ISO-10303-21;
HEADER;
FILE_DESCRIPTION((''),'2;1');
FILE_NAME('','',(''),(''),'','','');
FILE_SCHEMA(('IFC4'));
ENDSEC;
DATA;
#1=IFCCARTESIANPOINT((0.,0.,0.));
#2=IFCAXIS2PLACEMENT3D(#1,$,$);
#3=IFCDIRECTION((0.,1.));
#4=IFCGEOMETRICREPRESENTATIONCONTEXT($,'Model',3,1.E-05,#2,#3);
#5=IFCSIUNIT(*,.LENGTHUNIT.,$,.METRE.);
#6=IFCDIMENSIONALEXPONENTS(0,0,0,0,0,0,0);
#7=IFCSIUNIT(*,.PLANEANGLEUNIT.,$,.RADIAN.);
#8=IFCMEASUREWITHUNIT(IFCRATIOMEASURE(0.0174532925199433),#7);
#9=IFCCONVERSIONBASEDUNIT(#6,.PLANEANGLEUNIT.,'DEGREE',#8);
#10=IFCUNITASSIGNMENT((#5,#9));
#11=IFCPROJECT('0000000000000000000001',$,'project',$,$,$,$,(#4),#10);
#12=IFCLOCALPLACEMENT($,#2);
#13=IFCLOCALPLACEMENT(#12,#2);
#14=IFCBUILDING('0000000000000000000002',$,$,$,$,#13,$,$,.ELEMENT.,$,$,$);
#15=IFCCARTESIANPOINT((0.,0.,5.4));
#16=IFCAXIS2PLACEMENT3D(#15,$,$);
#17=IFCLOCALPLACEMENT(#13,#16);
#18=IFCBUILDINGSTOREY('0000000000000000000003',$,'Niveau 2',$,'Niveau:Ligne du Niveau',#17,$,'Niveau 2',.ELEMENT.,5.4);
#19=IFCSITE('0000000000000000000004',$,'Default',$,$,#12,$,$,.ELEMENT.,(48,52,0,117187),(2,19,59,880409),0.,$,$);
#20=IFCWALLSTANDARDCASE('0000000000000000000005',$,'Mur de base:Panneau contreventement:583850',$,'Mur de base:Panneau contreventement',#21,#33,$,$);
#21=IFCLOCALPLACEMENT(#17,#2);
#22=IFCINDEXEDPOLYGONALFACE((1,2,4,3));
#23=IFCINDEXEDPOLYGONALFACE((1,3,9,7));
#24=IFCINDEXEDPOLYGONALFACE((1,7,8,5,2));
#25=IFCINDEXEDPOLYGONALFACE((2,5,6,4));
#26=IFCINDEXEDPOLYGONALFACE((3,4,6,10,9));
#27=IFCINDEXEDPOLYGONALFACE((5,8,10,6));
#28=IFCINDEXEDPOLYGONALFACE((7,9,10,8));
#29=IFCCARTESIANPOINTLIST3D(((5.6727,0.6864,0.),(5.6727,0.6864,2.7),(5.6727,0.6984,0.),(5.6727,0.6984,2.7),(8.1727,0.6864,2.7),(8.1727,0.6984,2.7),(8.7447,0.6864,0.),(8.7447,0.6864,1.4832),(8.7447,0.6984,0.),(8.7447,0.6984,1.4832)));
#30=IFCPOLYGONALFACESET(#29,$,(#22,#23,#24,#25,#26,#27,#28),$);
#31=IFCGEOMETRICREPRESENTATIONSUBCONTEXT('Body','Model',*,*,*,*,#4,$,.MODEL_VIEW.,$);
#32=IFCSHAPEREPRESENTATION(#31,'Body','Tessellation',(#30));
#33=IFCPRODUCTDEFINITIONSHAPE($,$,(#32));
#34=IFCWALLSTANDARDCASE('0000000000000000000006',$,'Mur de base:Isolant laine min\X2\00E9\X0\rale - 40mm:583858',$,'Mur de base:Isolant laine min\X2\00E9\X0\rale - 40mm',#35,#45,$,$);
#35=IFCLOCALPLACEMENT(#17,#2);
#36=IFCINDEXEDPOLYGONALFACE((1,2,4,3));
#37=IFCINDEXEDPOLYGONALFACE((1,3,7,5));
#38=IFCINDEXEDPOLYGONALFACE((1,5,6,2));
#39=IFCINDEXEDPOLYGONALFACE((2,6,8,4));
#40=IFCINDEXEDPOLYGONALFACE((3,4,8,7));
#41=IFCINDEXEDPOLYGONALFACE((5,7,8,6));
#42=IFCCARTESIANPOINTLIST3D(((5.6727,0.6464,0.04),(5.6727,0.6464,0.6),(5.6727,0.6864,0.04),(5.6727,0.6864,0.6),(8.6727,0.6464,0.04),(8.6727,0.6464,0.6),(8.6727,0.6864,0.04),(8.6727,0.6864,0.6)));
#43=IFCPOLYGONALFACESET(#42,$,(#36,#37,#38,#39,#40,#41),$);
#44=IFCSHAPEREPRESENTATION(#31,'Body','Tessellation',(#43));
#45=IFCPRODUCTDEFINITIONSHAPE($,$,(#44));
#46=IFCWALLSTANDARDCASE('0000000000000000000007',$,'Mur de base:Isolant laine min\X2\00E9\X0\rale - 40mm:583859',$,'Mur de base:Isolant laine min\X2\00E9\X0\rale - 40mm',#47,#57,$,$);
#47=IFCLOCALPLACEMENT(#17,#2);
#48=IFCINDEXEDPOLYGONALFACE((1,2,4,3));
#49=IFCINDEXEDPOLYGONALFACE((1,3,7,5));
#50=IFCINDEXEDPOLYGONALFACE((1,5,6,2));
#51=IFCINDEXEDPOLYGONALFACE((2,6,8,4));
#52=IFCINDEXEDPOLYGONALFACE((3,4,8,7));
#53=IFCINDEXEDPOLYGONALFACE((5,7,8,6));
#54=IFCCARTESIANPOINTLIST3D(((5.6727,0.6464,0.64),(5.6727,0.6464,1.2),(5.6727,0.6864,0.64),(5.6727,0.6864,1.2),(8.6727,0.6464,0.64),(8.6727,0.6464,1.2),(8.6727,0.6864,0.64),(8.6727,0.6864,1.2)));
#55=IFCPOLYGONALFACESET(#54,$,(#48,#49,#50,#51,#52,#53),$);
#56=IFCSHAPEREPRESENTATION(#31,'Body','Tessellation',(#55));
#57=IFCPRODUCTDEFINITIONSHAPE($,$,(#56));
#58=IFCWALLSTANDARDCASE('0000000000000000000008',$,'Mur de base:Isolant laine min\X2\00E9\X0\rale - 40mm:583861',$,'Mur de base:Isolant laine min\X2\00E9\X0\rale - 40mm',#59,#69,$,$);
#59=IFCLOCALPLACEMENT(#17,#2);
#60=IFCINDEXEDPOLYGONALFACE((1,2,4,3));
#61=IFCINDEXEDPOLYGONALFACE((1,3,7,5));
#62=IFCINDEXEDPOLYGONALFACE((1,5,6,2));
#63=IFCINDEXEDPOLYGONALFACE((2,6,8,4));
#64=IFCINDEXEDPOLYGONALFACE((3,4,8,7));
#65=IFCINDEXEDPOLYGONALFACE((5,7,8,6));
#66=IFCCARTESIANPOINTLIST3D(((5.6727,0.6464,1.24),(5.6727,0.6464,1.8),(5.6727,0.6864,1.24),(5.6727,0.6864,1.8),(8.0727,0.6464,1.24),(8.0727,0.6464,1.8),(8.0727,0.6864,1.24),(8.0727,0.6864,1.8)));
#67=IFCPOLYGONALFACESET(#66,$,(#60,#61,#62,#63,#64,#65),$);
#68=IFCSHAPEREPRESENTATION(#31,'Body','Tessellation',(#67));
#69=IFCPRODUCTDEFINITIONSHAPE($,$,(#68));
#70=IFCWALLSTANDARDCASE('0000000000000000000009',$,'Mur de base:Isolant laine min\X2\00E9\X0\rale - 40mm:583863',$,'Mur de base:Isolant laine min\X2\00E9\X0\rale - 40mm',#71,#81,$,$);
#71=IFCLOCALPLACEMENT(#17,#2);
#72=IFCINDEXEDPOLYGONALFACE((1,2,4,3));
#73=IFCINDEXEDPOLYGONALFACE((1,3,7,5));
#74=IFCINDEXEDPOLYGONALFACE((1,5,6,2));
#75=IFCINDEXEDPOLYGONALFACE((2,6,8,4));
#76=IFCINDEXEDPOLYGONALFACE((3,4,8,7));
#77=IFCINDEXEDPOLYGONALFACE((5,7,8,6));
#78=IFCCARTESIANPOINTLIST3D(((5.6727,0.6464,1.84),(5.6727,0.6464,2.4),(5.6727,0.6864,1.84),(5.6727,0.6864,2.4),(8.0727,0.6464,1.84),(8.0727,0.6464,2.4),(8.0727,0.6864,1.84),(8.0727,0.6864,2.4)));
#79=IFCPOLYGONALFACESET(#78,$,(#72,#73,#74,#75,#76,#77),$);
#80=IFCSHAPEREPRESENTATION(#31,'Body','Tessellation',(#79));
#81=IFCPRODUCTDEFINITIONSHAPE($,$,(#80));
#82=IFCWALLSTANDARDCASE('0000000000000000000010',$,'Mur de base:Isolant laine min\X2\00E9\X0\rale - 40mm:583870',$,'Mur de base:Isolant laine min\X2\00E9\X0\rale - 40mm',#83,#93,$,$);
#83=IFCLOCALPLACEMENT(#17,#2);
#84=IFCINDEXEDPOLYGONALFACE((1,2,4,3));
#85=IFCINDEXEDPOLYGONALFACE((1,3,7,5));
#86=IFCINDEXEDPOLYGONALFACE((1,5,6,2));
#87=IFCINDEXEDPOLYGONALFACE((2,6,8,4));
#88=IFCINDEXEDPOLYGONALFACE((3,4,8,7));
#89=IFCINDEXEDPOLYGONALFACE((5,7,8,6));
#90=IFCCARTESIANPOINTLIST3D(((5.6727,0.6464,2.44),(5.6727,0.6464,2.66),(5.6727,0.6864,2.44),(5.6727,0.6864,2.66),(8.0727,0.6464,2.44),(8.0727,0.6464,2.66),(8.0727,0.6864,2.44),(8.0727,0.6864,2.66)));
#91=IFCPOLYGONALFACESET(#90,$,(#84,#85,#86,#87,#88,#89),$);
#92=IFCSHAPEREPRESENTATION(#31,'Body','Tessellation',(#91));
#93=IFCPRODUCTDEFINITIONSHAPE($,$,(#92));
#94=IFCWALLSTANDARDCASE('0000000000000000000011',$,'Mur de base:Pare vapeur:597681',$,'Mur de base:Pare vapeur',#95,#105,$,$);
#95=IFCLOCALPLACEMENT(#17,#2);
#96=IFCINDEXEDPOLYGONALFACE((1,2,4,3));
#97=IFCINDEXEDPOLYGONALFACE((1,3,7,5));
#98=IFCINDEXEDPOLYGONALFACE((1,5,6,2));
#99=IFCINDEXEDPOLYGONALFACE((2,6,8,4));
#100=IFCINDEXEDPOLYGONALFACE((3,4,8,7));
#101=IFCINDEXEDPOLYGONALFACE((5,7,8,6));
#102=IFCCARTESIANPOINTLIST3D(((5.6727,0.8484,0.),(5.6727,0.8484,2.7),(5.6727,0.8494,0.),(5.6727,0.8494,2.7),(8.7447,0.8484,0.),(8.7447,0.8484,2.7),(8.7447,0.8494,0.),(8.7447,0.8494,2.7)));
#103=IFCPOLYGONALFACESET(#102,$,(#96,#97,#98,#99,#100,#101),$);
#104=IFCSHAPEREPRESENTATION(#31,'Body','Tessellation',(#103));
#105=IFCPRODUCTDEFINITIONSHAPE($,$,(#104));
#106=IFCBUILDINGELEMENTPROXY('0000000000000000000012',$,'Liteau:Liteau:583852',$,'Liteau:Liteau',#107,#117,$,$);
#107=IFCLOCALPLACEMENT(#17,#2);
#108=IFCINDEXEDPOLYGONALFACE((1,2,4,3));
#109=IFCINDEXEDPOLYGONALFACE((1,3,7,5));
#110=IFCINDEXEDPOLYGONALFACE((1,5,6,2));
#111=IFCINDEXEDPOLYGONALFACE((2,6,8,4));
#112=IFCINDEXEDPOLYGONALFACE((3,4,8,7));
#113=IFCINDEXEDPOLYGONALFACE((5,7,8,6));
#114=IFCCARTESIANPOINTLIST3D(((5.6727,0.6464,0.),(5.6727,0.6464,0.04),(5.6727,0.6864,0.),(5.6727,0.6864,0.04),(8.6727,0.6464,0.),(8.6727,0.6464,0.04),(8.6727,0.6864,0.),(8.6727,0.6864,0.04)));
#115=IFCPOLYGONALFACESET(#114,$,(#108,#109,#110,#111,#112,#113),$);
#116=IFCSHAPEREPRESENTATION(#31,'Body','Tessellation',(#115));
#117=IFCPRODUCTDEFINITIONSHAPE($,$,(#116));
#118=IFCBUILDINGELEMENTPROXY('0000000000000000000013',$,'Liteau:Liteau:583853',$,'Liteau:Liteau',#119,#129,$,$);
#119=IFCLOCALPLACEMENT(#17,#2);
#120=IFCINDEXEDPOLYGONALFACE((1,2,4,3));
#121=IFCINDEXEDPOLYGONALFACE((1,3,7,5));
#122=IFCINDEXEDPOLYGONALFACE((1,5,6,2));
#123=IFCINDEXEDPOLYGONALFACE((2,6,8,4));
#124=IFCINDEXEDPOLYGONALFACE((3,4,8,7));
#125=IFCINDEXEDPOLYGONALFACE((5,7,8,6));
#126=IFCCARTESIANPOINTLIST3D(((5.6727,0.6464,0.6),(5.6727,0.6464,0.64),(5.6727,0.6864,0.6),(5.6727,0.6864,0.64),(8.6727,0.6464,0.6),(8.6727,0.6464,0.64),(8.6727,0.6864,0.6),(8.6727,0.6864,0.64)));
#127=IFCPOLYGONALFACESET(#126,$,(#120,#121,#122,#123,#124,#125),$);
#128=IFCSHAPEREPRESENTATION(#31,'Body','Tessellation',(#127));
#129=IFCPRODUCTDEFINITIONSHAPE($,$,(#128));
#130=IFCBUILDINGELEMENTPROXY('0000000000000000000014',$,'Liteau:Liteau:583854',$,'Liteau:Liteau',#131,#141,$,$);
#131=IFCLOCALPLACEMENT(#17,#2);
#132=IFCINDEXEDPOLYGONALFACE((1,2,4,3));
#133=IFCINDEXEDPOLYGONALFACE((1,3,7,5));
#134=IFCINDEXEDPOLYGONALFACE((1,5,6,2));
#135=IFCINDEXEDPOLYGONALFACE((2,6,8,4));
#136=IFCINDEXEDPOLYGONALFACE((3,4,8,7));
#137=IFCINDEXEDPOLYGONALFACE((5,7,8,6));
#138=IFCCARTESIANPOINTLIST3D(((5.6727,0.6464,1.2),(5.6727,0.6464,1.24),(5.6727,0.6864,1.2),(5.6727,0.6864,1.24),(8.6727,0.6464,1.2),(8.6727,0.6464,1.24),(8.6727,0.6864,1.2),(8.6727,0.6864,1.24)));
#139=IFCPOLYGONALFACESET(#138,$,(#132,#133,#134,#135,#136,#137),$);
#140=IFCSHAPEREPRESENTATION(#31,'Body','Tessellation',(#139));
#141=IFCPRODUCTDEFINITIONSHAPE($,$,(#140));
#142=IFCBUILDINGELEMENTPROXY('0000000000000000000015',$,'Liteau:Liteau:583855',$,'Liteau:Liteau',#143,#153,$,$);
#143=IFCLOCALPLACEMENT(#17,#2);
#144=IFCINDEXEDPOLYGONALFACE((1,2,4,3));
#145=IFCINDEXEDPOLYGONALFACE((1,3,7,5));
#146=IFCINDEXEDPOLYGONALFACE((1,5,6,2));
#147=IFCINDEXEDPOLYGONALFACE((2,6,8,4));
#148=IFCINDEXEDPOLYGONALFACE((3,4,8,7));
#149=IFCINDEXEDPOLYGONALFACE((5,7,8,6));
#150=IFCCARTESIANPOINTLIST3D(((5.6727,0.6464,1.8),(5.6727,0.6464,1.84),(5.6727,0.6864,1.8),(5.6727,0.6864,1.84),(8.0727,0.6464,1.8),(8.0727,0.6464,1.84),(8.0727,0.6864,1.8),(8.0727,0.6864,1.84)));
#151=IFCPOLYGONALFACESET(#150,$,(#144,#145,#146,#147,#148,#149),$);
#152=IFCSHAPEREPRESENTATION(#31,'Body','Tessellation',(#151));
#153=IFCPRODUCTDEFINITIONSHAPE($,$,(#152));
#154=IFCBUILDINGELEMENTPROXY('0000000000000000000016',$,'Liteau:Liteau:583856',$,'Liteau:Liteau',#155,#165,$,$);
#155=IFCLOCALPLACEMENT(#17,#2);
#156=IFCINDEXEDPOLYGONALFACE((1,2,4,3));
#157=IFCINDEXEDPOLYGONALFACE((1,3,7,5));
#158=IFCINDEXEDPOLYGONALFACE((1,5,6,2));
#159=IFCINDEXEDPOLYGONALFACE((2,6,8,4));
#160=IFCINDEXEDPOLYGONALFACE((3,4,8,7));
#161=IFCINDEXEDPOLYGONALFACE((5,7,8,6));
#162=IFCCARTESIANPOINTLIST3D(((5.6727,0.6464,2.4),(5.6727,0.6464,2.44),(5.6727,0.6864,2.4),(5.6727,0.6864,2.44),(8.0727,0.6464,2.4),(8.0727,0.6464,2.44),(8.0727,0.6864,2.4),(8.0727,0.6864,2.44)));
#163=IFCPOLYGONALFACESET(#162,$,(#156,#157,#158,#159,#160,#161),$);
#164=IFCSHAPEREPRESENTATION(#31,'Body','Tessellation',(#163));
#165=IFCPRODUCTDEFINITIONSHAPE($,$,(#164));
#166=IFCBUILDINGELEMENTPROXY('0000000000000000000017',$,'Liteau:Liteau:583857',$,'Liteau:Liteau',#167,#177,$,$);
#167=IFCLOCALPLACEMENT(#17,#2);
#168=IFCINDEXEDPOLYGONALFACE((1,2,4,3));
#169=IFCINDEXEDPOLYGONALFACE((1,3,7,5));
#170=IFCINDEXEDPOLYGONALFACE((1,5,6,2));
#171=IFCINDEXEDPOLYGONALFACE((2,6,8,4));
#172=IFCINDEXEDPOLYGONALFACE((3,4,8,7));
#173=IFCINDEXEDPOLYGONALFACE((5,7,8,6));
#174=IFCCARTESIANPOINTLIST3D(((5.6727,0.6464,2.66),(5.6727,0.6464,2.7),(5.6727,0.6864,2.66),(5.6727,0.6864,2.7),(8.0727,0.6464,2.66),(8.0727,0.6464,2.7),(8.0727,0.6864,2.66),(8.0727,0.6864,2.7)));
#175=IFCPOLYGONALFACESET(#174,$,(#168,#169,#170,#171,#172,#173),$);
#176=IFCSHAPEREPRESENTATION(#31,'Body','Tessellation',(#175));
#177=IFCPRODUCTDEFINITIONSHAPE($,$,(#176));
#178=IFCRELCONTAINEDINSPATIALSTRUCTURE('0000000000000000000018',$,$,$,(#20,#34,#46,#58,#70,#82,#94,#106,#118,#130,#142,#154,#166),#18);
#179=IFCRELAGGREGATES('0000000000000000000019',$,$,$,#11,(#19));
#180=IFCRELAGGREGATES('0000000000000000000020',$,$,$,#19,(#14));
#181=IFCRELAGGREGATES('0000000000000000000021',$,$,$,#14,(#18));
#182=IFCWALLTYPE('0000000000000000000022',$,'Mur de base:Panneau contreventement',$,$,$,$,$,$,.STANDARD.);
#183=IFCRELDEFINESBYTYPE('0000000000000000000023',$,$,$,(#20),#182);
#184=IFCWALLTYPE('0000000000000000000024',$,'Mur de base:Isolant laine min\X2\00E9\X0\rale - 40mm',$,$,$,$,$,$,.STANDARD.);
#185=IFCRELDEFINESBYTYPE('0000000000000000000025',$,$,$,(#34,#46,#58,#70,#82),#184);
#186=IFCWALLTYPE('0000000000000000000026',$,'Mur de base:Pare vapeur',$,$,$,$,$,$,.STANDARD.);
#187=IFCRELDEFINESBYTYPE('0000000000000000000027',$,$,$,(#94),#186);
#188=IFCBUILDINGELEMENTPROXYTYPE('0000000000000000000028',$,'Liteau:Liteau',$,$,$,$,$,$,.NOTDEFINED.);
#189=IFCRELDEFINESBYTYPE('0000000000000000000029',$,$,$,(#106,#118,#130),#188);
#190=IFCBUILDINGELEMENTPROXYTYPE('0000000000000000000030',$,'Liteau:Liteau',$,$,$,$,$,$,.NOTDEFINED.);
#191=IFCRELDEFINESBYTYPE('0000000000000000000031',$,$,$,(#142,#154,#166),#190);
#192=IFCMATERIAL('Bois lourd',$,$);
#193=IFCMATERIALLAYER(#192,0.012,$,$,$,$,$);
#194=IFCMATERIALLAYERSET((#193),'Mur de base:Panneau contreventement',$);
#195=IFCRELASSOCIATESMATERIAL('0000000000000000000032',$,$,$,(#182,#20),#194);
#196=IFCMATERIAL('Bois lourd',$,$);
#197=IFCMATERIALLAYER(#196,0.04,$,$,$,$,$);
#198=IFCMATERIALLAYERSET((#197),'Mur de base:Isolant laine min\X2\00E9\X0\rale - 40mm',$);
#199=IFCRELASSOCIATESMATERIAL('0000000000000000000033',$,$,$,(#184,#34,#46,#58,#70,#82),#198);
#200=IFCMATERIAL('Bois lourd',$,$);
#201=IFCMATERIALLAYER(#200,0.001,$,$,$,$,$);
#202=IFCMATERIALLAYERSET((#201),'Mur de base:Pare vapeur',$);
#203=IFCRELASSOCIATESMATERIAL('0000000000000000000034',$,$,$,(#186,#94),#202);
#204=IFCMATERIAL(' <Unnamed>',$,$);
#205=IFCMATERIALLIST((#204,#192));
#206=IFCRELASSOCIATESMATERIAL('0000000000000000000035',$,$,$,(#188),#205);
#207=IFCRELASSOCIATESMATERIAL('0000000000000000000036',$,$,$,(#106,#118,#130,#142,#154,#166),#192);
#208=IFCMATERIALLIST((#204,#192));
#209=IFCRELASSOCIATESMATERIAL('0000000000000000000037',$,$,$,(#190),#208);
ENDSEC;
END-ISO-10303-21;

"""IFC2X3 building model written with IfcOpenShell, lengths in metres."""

from ifc_helpers import new_model, entity, si_unit, converted_unit, direction, frame, frame_2d, origin, origin_2d_with_axis, place, context, subcontext, project, spatial, rectangle, extrude, clip, halfspace, source, transform, mapped, material, material_list, layer, layer_set, layer_usage, type_object, type_shapes, element, save


model = new_model("IFC2X3")

# Units and contexts
model_context = context("Model", 3, precision=1e-05, world=origin(), true_north=direction((0.0, 1.0)))
body_context = subcontext(model_context, "Body", "Model", "MODEL_VIEW")
ifc_project = project(units=[si_unit("LENGTHUNIT", "METRE"), converted_unit("PLANEANGLEUNIT", "DEGREE", entity("IfcRatioMeasure", 0.0174532925199433), si_unit("PLANEANGLEUNIT", "RADIAN"), dimensions=[0, 0, 0, 0, 0, 0, 0])], contexts=[model_context])

# Site, building, storey
site_placement = place(None, origin())
site = spatial("IfcSite", under=ifc_project, at=site_placement, Name="Default", CompositionType="ELEMENT", RefLatitude=(48, 52, 0, 117187), RefLongitude=(2, 19, 59, 880409), RefElevation=0.0)
building_placement = place(site_placement, origin())
building = spatial("IfcBuilding", under=site, at=building_placement, CompositionType="ELEMENT")
storey_placement = place(building_placement, frame((0.0, 0.0, 5.4)))
storey = spatial("IfcBuildingStorey", under=building, at=storey_placement, Name="Niveau 2", ObjectType="Niveau:Ligne du Niveau", LongName="Niveau 2", CompositionType="ELEMENT", Elevation=5.4)

# Shared definitions
ifc_material_1 = material(Name="Bois lourd")

# Walls
ifc_layer_1 = layer(ifc_material_1, 0.012)
ifc_layer_set_1 = layer_set([ifc_layer_1], Name="Mur de base:Panneau contreventement")
ifc_layer_usage_1 = layer_usage(ifc_layer_set_1, "AXIS2", "NEGATIVE", 0.006)
wall_type_1 = type_object("IfcWallType", Name="Mur de base:Panneau contreventement", PredefinedType="STANDARD", material=ifc_layer_set_1)
wall_1_placement = place(storey_placement, frame((5.6727, 0.6924, 0.0)))
element("IfcWallStandardCase", 1, at=wall_1_placement, inside=storey, type_object=wall_type_1, material=ifc_layer_usage_1, Name="Mur de base:Panneau contreventement:583850", ObjectType="Mur de base:Panneau contreventement", context=body_context, shape_type="Clipping", body=[
    clip(extrude(rectangle(XDim=3.072, YDim=0.012, at=frame_2d((1.536, 0.0), x_axis=(-1.0, 0.0))), origin(), (0.0, 0.0, 1.0), 2.7), halfspace(frame((2.5, -0.006, 2.7), z_axis=(0.904996, 0.0, 0.425419), x_axis=(0.0, 1.0, 0.0)), False)),
])
ifc_material_2 = material(Name="Bois lourd")
ifc_layer_2 = layer(ifc_material_2, 0.04)
ifc_layer_set_2 = layer_set([ifc_layer_2], Name="Mur de base:Isolant laine minérale - 40mm")
ifc_layer_usage_2 = layer_usage(ifc_layer_set_2, "AXIS2", "NEGATIVE", 0.02)
wall_type_2 = type_object("IfcWallType", Name="Mur de base:Isolant laine minérale - 40mm", PredefinedType="STANDARD", material=ifc_layer_set_2)
wall_2_placement = place(storey_placement, frame((5.6727, 0.6664, 0.04)))
element("IfcWallStandardCase", 2, at=wall_2_placement, inside=storey, type_object=wall_type_2, material=ifc_layer_usage_2, Name="Mur de base:Isolant laine minérale - 40mm:583858", ObjectType="Mur de base:Isolant laine minérale - 40mm", context=body_context, shape_type="SweptSolid", body=[
    extrude(rectangle(XDim=3.0, YDim=0.04, at=frame_2d((1.5, 0.0), x_axis=(-1.0, 0.0))), origin(), (0.0, 0.0, 1.0), 0.56),
])
ifc_layer_usage_3 = layer_usage(ifc_layer_set_2, "AXIS2", "NEGATIVE", 0.02)
wall_3_placement = place(storey_placement, frame((5.6727, 0.6664, 0.64)))
element("IfcWallStandardCase", 3, at=wall_3_placement, inside=storey, type_object=wall_type_2, material=ifc_layer_usage_3, Name="Mur de base:Isolant laine minérale - 40mm:583859", ObjectType="Mur de base:Isolant laine minérale - 40mm", context=body_context, shape_type="SweptSolid", body=[
    extrude(rectangle(XDim=3.0, YDim=0.04, at=frame_2d((1.5, 0.0), x_axis=(-1.0, 0.0))), origin(), (0.0, 0.0, 1.0), 0.56),
])
ifc_layer_usage_4 = layer_usage(ifc_layer_set_2, "AXIS2", "NEGATIVE", 0.02)
wall_4_placement = place(storey_placement, frame((5.6727, 0.6664, 1.24)))
element("IfcWallStandardCase", 4, at=wall_4_placement, inside=storey, type_object=wall_type_2, material=ifc_layer_usage_4, Name="Mur de base:Isolant laine minérale - 40mm:583861", ObjectType="Mur de base:Isolant laine minérale - 40mm", context=body_context, shape_type="SweptSolid", body=[
    extrude(rectangle(XDim=2.4, YDim=0.04, at=frame_2d((1.2, 0.0), x_axis=(-1.0, 0.0))), origin(), (0.0, 0.0, 1.0), 0.56),
])
ifc_layer_usage_5 = layer_usage(ifc_layer_set_2, "AXIS2", "NEGATIVE", 0.02)
wall_5_placement = place(storey_placement, frame((5.6727, 0.6664, 1.84)))
element("IfcWallStandardCase", 5, at=wall_5_placement, inside=storey, type_object=wall_type_2, material=ifc_layer_usage_5, Name="Mur de base:Isolant laine minérale - 40mm:583863", ObjectType="Mur de base:Isolant laine minérale - 40mm", context=body_context, shape_type="SweptSolid", body=[
    extrude(rectangle(XDim=2.4, YDim=0.04, at=frame_2d((1.2, 0.0), x_axis=(-1.0, 0.0))), origin(), (0.0, 0.0, 1.0), 0.56),
])
ifc_layer_usage_6 = layer_usage(ifc_layer_set_2, "AXIS2", "NEGATIVE", 0.02)
wall_6_placement = place(storey_placement, frame((5.6727, 0.6664, 2.44)))
element("IfcWallStandardCase", 6, at=wall_6_placement, inside=storey, type_object=wall_type_2, material=ifc_layer_usage_6, Name="Mur de base:Isolant laine minérale - 40mm:583870", ObjectType="Mur de base:Isolant laine minérale - 40mm", context=body_context, shape_type="SweptSolid", body=[
    extrude(rectangle(XDim=2.4, YDim=0.04, at=frame_2d((1.2, 0.0), x_axis=(-1.0, 0.0))), origin(), (0.0, 0.0, 1.0), 0.22),
])
ifc_material_3 = material(Name="Bois lourd")
ifc_layer_3 = layer(ifc_material_3, 0.001)
ifc_layer_set_3 = layer_set([ifc_layer_3], Name="Mur de base:Pare vapeur")
ifc_layer_usage_7 = layer_usage(ifc_layer_set_3, "AXIS2", "NEGATIVE", 0.0005)
wall_type_3 = type_object("IfcWallType", Name="Mur de base:Pare vapeur", PredefinedType="STANDARD", material=ifc_layer_set_3)
wall_7_placement = place(storey_placement, frame((5.6727, 0.8489, 0.0)))
element("IfcWallStandardCase", 7, at=wall_7_placement, inside=storey, type_object=wall_type_3, material=ifc_layer_usage_7, Name="Mur de base:Pare vapeur:597681", ObjectType="Mur de base:Pare vapeur", context=body_context, shape_type="SweptSolid", body=[
    extrude(rectangle(XDim=3.072, YDim=0.001, at=frame_2d((1.536, 0.0), x_axis=(-1.0, 0.0))), origin(), (0.0, 0.0, 1.0), 2.7),
])

# Building element proxies
ifc_material_4 = material(Name=" <Unnamed>")
ifc_material_list_1 = material_list([ifc_material_4, ifc_material_1])
building_element_proxy_type_1 = type_object("IfcBuildingElementProxyType", Name="Liteau:Liteau", PredefinedType="NOTDEFINED", material=ifc_material_list_1)
shared_shape_1 = source(origin(), body_context, "Body", "SweptSolid", [
    extrude(rectangle(XDim=3.0, YDim=0.04, at=origin_2d_with_axis()), frame((1.5, -0.02, 0.0), z_axis=(0.0, 0.0, 1.0), x_axis=(-1.0, 0.0, 0.0)), (0.0, 0.0, 1.0), 0.04),
])
type_shapes(building_element_proxy_type_1, [shared_shape_1])
for number, where, name in (
    (8, (5.6727, 0.6864, 0.0), "Liteau:Liteau:583852"),
    (9, (5.6727, 0.6864, 0.6), "Liteau:Liteau:583853"),
    (10, (5.6727, 0.6864, 1.2), "Liteau:Liteau:583854"),
):
    element("IfcBuildingElementProxy", number, at=place(storey_placement, frame(where)), inside=storey, type_object=building_element_proxy_type_1, material=ifc_material_1, Name=name, ObjectType="Liteau:Liteau", context=body_context, shape_type="MappedRepresentation", body=[
        mapped(shared_shape_1, transform((0.0, 0.0, 0.0), scale=1.0)),
    ])
ifc_material_list_2 = material_list([ifc_material_4, ifc_material_1])
building_element_proxy_type_2 = type_object("IfcBuildingElementProxyType", Name="Liteau:Liteau", PredefinedType="NOTDEFINED", material=ifc_material_list_2)
shared_shape_2 = source(origin(), body_context, "Body", "SweptSolid", [
    extrude(rectangle(XDim=2.4, YDim=0.04, at=origin_2d_with_axis()), frame((1.2, -0.02, 0.0), z_axis=(0.0, 0.0, 1.0), x_axis=(-1.0, 0.0, 0.0)), (0.0, 0.0, 1.0), 0.04),
])
type_shapes(building_element_proxy_type_2, [shared_shape_2])
for number, where, name in (
    (11, (5.6727, 0.6864, 1.8), "Liteau:Liteau:583855"),
    (12, (5.6727, 0.6864, 2.4), "Liteau:Liteau:583856"),
    (13, (5.6727, 0.6864, 2.66), "Liteau:Liteau:583857"),
):
    element("IfcBuildingElementProxy", number, at=place(storey_placement, frame(where)), inside=storey, type_object=building_element_proxy_type_2, material=ifc_material_1, Name=name, ObjectType="Liteau:Liteau", context=body_context, shape_type="MappedRepresentation", body=[
        mapped(shared_shape_2, transform((0.0, 0.0, 0.0), scale=1.0)),
    ])

save(model, "model.ifc")
